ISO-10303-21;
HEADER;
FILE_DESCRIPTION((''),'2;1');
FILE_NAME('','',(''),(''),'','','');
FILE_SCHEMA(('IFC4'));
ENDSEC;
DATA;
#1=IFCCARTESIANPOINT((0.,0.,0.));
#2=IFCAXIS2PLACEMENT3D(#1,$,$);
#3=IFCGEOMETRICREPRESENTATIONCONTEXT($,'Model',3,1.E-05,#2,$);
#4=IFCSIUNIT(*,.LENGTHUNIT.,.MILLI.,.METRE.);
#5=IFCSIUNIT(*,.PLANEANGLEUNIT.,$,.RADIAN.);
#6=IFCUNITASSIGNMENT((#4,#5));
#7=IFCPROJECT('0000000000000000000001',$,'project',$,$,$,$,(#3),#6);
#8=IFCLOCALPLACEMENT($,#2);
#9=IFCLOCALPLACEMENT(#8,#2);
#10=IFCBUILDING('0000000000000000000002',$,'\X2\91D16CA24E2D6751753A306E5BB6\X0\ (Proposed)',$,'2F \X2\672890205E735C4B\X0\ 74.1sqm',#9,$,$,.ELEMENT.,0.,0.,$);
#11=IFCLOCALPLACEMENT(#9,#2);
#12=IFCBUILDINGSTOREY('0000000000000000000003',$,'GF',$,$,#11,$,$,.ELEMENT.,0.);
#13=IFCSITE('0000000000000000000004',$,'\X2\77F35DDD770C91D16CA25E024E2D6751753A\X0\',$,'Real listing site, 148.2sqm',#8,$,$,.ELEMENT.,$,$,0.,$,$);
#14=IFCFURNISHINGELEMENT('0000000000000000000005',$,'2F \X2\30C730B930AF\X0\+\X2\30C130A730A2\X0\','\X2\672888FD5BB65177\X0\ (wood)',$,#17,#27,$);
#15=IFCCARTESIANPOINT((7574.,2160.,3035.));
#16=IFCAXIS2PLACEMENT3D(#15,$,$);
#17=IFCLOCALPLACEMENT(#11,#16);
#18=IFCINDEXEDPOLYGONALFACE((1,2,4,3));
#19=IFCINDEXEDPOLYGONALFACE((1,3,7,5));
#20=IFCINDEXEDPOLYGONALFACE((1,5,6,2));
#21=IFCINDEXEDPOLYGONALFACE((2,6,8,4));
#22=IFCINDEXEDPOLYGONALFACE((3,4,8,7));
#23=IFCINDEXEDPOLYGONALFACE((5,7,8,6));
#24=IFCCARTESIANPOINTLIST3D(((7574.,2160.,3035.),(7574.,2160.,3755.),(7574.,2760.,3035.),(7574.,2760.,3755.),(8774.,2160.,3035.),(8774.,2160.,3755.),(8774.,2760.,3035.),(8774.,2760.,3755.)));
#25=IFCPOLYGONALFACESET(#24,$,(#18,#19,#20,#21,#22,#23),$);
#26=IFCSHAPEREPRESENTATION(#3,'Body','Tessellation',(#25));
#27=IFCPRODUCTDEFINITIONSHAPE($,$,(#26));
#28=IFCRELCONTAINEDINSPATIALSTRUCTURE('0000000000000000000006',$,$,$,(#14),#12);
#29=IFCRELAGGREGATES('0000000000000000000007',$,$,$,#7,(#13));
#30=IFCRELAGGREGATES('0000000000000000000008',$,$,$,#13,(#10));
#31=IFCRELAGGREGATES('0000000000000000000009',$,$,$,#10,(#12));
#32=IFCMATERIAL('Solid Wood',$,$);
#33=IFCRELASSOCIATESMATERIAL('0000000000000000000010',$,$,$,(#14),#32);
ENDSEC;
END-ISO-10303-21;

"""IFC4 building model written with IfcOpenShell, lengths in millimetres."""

from ifc_helpers import new_model, si_unit, frame, frame_2d, origin, place, context, project, spatial, rectangle, extrude, material, element, save


model = new_model("IFC4")

# Units and contexts
model_context = context("Model", 3, precision=1e-05, world=origin())
ifc_project = project(units=[si_unit("LENGTHUNIT", "METRE", prefix="MILLI"), si_unit("PLANEANGLEUNIT", "RADIAN")], contexts=[model_context])

# Site, building, storey
site_placement = place(None, origin())
site = spatial("IfcSite", under=ifc_project, at=site_placement, Name="石川県金沢市中村町", ObjectType="Real listing site, 148.2sqm", CompositionType="ELEMENT", RefElevation=0.0)
building_placement = place(site_placement, origin())
building = spatial("IfcBuilding", under=site, at=building_placement, Name="金沢中村町の家 (Proposed)", ObjectType="2F 木造平屋 74.1sqm", CompositionType="ELEMENT", ElevationOfRefHeight=0.0, ElevationOfTerrain=0.0)
storey_placement = place(building_placement, origin())
storey = spatial("IfcBuildingStorey", under=building, at=storey_placement, Name="GF", CompositionType="ELEMENT", Elevation=0.0)

# Shared definitions
ifc_material_1 = material(Name="Solid Wood")

# Furnishing element
furnishing_1_placement = place(storey_placement, frame((7574.0, 2160.0, 3035.0)))
element("IfcFurnishingElement", 1, at=furnishing_1_placement, inside=storey, material=ifc_material_1, Name="2F デスク+チェア", Description="木製家具 (wood)", context=model_context, shape_type="SweptSolid", body=[
    extrude(rectangle(XDim=1200.0, YDim=600.0, at=frame_2d((600.0, 300.0))), frame((7574.0, 2160.0, 3035.0)), (0.0, 0.0, 1.0), 720.0),
])

save(model, "model.ifc")
